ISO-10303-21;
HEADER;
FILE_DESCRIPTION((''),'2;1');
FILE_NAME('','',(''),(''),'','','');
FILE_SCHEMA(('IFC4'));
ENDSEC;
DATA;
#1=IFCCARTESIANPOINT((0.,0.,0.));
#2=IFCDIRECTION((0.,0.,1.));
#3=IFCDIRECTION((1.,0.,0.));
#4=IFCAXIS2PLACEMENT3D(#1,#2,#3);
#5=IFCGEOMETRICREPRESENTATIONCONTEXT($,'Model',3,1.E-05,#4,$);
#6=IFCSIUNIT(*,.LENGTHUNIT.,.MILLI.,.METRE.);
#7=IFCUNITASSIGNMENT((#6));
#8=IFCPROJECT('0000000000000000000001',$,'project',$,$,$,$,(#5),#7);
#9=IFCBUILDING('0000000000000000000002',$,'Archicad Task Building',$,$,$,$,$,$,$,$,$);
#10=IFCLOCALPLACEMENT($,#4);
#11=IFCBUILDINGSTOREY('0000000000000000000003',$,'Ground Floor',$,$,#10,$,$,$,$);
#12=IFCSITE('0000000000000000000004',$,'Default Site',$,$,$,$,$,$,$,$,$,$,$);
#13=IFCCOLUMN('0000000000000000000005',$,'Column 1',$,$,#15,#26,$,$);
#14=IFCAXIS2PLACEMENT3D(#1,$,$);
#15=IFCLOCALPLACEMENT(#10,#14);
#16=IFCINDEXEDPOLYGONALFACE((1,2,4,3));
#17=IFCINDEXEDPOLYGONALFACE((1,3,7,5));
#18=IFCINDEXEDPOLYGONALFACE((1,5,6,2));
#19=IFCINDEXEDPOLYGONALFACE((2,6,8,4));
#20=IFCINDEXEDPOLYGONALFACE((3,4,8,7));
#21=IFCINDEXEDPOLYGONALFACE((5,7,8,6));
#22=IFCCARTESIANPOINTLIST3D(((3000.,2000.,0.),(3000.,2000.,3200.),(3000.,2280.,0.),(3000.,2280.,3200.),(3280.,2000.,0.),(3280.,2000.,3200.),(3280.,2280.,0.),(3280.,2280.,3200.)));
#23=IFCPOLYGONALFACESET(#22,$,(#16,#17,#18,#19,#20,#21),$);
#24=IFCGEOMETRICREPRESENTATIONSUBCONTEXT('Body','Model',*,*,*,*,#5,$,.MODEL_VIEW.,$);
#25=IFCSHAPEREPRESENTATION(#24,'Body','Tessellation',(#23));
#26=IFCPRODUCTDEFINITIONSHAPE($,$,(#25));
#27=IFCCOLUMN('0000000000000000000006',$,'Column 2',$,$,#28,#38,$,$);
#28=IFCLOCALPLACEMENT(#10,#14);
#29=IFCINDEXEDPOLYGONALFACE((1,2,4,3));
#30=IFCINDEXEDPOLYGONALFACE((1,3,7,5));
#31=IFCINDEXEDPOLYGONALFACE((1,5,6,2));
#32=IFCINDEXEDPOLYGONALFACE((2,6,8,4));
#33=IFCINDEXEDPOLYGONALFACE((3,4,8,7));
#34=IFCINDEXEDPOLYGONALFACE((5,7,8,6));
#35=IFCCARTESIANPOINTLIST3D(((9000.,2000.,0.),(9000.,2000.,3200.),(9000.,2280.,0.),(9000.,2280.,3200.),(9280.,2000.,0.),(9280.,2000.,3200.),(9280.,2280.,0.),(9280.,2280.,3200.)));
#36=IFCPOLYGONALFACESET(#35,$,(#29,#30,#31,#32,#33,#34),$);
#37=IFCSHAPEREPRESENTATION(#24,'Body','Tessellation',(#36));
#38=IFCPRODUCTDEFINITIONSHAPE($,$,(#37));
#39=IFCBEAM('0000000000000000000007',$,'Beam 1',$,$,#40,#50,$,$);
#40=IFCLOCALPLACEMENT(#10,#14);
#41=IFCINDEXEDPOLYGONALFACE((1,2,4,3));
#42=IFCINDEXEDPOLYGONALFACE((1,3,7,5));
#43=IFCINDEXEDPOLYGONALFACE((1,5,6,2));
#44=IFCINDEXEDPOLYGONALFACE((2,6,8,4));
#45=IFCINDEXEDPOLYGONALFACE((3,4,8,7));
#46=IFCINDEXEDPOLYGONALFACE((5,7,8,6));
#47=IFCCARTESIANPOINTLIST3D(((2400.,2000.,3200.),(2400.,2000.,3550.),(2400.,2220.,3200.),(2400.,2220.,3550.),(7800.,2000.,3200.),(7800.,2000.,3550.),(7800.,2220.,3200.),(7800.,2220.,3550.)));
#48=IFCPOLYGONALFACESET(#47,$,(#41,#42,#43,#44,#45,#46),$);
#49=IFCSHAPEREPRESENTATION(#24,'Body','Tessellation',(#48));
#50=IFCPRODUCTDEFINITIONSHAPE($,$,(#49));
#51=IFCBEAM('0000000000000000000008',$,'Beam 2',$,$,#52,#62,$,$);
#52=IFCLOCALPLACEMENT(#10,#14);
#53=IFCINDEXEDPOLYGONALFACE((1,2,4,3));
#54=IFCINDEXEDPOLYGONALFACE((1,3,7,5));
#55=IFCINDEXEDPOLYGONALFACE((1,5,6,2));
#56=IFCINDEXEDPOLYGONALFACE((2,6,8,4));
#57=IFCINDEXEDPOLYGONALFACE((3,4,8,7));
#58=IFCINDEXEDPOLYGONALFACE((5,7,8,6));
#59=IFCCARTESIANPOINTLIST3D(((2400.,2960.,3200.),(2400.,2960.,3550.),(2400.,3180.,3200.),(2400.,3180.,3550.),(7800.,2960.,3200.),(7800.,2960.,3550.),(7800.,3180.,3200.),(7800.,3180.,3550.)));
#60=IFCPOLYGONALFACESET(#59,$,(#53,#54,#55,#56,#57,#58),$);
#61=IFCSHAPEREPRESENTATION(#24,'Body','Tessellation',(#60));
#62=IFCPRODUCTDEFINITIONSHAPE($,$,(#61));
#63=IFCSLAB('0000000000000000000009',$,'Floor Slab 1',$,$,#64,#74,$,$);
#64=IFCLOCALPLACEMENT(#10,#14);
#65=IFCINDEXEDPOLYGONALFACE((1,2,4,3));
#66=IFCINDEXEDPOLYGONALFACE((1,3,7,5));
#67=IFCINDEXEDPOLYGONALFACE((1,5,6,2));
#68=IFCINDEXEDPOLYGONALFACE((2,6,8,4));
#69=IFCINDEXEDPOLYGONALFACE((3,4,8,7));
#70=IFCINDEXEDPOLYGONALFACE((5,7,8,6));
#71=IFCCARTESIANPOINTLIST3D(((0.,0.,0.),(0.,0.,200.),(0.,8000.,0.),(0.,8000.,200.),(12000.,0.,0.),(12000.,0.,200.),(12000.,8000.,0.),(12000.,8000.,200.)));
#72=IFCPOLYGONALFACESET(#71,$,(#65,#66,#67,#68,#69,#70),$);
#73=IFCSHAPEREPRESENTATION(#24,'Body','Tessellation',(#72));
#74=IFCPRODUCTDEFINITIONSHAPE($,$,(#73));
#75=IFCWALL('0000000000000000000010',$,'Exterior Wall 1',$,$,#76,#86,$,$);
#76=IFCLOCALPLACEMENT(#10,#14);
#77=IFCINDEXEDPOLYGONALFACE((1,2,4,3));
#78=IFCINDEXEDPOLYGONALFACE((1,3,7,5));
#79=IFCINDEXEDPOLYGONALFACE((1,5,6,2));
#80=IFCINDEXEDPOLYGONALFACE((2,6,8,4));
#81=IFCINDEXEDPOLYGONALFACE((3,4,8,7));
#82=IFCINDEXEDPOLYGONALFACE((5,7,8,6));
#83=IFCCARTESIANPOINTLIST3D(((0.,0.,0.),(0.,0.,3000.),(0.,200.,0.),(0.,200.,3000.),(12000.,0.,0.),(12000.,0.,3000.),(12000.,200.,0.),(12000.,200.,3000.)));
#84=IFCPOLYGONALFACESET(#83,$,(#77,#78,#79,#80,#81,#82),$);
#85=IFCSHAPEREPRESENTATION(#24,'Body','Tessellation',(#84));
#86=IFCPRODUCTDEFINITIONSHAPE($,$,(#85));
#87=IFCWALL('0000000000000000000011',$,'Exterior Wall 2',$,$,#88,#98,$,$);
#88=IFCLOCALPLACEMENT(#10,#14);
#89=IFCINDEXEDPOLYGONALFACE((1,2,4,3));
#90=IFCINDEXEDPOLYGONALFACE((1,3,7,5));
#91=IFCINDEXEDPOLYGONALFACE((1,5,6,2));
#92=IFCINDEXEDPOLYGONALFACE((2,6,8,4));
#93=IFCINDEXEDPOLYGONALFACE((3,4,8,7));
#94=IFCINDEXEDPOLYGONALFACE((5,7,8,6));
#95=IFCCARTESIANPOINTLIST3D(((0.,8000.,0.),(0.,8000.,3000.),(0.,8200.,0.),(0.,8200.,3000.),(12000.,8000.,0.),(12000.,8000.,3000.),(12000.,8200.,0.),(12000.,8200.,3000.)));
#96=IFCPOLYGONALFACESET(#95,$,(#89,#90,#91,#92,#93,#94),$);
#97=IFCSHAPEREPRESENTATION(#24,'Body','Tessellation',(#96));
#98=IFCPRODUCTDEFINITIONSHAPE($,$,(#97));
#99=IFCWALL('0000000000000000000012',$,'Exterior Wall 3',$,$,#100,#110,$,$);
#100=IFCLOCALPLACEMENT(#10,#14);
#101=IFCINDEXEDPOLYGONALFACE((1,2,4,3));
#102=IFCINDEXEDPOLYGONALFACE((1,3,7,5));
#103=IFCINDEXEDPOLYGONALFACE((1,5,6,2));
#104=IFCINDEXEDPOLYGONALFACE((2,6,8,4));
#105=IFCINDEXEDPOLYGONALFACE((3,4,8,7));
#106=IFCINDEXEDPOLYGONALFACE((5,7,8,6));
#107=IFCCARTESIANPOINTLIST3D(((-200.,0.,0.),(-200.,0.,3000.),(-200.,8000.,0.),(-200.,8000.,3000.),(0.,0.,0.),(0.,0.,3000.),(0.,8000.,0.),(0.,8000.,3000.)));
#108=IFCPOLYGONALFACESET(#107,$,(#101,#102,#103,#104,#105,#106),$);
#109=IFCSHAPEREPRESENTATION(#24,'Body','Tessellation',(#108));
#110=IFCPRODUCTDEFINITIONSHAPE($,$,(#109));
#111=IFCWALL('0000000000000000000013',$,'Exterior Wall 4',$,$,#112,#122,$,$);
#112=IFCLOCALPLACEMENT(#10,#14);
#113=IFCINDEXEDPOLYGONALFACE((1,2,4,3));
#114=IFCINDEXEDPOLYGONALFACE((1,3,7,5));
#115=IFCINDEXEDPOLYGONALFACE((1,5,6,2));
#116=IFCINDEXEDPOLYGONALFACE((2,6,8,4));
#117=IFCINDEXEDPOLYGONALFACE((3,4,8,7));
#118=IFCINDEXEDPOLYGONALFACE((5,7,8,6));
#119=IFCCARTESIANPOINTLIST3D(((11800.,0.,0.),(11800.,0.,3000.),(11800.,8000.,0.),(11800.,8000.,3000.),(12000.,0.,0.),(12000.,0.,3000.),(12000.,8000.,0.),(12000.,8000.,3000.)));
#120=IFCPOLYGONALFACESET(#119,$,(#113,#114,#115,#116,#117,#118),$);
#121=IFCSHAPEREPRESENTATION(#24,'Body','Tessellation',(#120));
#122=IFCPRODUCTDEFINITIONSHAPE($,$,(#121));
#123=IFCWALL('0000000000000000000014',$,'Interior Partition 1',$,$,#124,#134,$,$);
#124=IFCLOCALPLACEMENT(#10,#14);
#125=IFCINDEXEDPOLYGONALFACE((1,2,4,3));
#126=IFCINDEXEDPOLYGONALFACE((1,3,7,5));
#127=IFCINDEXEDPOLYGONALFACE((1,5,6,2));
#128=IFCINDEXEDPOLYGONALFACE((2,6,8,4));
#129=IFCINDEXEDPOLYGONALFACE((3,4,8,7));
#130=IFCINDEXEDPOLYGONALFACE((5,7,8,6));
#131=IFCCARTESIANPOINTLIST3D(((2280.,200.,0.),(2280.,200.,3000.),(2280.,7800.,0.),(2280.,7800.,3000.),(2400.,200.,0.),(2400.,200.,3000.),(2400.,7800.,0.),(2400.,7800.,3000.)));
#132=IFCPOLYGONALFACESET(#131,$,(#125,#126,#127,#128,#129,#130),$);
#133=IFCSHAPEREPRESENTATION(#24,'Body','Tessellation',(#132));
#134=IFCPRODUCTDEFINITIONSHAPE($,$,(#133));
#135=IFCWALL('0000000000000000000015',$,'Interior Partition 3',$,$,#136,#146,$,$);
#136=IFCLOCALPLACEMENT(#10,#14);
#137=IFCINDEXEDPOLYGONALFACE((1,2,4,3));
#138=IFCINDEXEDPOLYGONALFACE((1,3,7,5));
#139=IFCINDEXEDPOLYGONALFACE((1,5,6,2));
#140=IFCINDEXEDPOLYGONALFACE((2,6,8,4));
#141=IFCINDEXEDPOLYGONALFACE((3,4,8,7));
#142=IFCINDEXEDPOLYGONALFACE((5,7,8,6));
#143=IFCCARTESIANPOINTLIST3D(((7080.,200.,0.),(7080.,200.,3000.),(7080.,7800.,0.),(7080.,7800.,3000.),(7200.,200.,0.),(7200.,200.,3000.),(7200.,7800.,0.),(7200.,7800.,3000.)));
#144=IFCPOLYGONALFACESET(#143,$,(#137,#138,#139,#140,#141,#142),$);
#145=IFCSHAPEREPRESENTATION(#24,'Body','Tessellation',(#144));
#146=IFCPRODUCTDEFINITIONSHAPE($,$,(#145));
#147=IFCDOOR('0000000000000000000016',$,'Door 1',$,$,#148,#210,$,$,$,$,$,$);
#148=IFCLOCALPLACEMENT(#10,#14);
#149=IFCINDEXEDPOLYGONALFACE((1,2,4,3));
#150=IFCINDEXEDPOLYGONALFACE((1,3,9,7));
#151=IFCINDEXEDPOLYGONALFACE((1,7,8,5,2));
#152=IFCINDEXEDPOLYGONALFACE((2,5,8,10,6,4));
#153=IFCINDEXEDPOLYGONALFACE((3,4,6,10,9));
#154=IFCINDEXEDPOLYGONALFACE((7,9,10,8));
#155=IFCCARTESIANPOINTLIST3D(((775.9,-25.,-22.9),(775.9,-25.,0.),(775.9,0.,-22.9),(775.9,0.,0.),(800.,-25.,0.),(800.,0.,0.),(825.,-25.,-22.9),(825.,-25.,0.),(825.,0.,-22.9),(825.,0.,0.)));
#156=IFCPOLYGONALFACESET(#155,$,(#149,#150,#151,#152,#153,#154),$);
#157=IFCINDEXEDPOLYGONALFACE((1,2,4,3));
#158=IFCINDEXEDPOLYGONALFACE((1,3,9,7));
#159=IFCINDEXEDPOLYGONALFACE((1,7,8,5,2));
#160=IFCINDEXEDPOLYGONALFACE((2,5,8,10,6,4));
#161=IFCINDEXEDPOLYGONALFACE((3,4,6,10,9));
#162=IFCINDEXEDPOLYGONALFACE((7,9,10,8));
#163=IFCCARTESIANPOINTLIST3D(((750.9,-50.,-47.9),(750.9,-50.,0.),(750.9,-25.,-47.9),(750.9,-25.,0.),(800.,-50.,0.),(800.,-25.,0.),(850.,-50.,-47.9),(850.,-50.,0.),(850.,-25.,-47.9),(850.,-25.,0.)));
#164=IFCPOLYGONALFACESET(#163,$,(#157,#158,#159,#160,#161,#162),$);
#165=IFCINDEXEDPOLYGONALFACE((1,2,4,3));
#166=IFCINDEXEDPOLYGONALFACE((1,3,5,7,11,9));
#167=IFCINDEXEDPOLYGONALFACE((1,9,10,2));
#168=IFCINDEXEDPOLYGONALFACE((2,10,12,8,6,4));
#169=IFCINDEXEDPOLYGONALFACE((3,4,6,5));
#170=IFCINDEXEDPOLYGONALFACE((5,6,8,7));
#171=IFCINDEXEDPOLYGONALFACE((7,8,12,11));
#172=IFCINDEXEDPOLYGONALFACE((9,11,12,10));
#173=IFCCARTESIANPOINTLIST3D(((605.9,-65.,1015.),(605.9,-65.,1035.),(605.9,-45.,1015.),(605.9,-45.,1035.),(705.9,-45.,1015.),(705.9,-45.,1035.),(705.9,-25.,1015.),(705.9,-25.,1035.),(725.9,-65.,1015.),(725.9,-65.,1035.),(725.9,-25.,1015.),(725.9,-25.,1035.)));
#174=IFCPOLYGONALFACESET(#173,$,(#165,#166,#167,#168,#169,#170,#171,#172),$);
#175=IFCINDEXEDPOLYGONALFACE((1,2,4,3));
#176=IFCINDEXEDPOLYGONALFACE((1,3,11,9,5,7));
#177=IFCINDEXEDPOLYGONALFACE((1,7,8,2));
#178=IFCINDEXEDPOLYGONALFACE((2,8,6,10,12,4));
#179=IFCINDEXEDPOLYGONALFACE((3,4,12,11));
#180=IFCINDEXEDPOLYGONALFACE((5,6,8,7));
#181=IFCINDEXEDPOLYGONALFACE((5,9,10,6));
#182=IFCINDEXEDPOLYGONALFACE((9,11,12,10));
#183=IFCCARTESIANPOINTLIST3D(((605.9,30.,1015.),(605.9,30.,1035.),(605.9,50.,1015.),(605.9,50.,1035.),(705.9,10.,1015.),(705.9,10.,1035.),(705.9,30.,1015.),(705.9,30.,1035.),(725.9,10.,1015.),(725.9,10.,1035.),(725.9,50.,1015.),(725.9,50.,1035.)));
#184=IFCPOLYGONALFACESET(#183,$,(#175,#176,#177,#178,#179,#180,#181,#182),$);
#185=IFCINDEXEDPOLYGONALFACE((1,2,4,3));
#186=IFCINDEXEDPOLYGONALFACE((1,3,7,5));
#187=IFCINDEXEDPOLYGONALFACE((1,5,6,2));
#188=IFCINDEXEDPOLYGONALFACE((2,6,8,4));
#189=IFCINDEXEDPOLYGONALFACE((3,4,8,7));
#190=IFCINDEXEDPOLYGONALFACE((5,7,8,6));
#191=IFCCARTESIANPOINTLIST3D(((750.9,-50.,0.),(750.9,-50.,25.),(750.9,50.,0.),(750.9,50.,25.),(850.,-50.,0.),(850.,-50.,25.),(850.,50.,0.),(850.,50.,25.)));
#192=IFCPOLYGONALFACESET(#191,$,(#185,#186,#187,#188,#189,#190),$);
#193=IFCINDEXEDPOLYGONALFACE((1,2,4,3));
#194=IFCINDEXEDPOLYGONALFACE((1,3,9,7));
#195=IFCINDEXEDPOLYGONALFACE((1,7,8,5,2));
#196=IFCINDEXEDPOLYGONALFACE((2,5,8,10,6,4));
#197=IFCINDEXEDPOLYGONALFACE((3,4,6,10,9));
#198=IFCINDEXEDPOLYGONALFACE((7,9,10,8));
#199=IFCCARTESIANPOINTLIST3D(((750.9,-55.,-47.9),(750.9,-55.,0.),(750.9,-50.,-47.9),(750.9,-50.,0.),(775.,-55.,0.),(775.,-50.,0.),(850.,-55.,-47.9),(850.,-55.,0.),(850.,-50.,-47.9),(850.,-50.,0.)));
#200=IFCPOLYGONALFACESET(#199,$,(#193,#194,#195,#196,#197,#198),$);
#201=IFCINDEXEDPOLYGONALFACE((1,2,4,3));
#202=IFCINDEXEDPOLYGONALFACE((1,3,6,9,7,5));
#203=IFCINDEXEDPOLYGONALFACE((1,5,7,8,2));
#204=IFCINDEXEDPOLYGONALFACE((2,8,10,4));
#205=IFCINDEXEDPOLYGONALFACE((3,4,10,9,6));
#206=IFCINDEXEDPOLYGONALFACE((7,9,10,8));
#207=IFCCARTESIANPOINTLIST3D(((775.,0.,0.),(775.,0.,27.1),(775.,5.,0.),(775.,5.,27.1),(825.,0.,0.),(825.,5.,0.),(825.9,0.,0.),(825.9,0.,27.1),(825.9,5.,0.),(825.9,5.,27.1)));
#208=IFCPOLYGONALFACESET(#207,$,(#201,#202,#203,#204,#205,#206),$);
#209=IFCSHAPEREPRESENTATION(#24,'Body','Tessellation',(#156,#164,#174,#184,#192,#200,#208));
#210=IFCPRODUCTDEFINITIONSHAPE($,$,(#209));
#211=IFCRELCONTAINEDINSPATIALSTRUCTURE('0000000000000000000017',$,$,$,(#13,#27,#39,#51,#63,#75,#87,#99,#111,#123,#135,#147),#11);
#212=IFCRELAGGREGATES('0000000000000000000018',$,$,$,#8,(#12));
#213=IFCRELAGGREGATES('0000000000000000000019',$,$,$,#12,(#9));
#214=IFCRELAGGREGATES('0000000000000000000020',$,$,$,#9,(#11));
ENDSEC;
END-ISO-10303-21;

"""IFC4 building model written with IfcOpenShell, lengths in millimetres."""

from ifc_helpers import new_model, si_unit, frame, origin_with_axes, place, context, subcontext, project, spatial, line, indexed_curve, outline, extrude, element, save


model = new_model("IFC4")

# Units and contexts
model_context = context("Model", 3, precision=1e-05, world=origin_with_axes())
body_context = subcontext(model_context, "Body", "Model", "MODEL_VIEW")
ifc_project = project(units=[si_unit("LENGTHUNIT", "METRE", prefix="MILLI")], contexts=[model_context])

# Site, building, storey
site = spatial("IfcSite", under=ifc_project, Name="Default Site")
building = spatial("IfcBuilding", under=site, Name="Archicad Task Building")
storey_placement = place(None, origin_with_axes())
storey = spatial("IfcBuildingStorey", under=building, at=storey_placement, Name="Ground Floor")

# Columns
for number, where, z_axis, x_axis, name in (
    (1, (3000.0, 2000.0, 0.0), (0.0, 0.0, 1.0), (1.0, 0.0, 0.0), "Column 1"),
    (2, (9000.0, 2000.0, 0.0), (0.0, 0.0, 1.0), (1.0, 0.0, 0.0), "Column 2"),
):
    element("IfcColumn", number, at=place(storey_placement, frame(where, z_axis=z_axis, x_axis=x_axis)), inside=storey, Name=name, context=body_context, shape_type="SweptSolid", body=[
        extrude(outline(indexed_curve([(0.0, 0.0), (0.0, 280.0), (280.0, 280.0), (280.0, 0.0), (0.0, 0.0)], self_intersect=False)), origin_with_axes(), (0.0, 0.0, 1.0), 3200.0),
    ])

# Beams
for number, where, z_axis, x_axis, name in (
    (3, (2400.0, 2000.0, 3200.0), (0.0, 0.0, 1.0), (1.0, 0.0, 0.0), "Beam 1"),
    (4, (2400.0, 2960.0, 3200.0), (0.0, 0.0, 1.0), (1.0, 0.0, 0.0), "Beam 2"),
):
    element("IfcBeam", number, at=place(storey_placement, frame(where, z_axis=z_axis, x_axis=x_axis)), inside=storey, Name=name, context=body_context, shape_type="SweptSolid", body=[
        extrude(outline(indexed_curve([(0.0, 0.0), (0.0, 220.0), (5400.0, 220.0), (5400.0, 0.0), (0.0, 0.0)], self_intersect=False)), origin_with_axes(), (0.0, 0.0, 1.0), 350.0),
    ])

# Slab
slab_placement = place(storey_placement, origin_with_axes())
element("IfcSlab", 5, at=slab_placement, inside=storey, Name="Floor Slab 1", context=body_context, shape_type="SweptSolid", body=[
    extrude(outline(indexed_curve([(0.0, 0.0), (12000.0, 0.0), (12000.0, 8000.0), (0.0, 8000.0), (0.0, 0.0)])), None, (0.0, 0.0, 1.0), 200.0),
])

# Walls
for number, where, z_axis, x_axis, name in (
    (6, (0.0, 0.0, 0.0), (0.0, 0.0, 1.0), (1.0, 0.0, 0.0), "Exterior Wall 1"),
    (7, (0.0, 8000.0, 0.0), (0.0, 0.0, 1.0), (1.0, 0.0, 0.0), "Exterior Wall 2"),
):
    element("IfcWall", number, at=place(storey_placement, frame(where, z_axis=z_axis, x_axis=x_axis)), inside=storey, Name=name, context=body_context, shape_type="SweptSolid", body=[
        extrude(outline(indexed_curve([(0.0, 0.0), (0.0, 200.0), (12000.0, 200.0), (12000.0, 0.0), (0.0, 0.0)], self_intersect=False)), origin_with_axes(), (0.0, 0.0, 1.0), 3000.0),
    ])
for number, where, z_axis, x_axis, name in (
    (8, (0.0, 0.0, 0.0), (0.0, 0.0, 1.0), (0.0, 1.0, 0.0), "Exterior Wall 3"),
    (9, (12000.0, 0.0, 0.0), (0.0, 0.0, 1.0), (0.0, 1.0, 0.0), "Exterior Wall 4"),
):
    element("IfcWall", number, at=place(storey_placement, frame(where, z_axis=z_axis, x_axis=x_axis)), inside=storey, Name=name, context=body_context, shape_type="SweptSolid", body=[
        extrude(outline(indexed_curve([(0.0, 0.0), (0.0, 200.0), (8000.0, 200.0), (8000.0, 0.0), (0.0, 0.0)], self_intersect=False)), origin_with_axes(), (0.0, 0.0, 1.0), 3000.0),
    ])
for number, where, z_axis, x_axis, name in (
    (10, (2400.0, 200.0, 0.0), (0.0, 0.0, 1.0), (0.0, 1.0, 0.0), "Interior Partition 1"),
    (11, (7200.0, 200.0, 0.0), (0.0, 0.0, 1.0), (0.0, 1.0, 0.0), "Interior Partition 3"),
):
    element("IfcWall", number, at=place(storey_placement, frame(where, z_axis=z_axis, x_axis=x_axis)), inside=storey, Name=name, context=body_context, shape_type="SweptSolid", body=[
        extrude(outline(indexed_curve([(0.0, 0.0), (0.0, 120.0), (7600.0, 120.0), (7600.0, 0.0), (0.0, 0.0)], self_intersect=False)), origin_with_axes(), (0.0, 0.0, 1.0), 3000.0),
    ])

# Door
door_1_placement = place(storey_placement, frame((800.0, -50.0, 0.0), z_axis=(0.0, 0.0, 1.0), x_axis=(1.0, 0.0, 0.0)))
element("IfcDoor", 12, at=door_1_placement, inside=storey, Name="Door 1", context=body_context, shape_type="SweptSolid", body=[
    extrude(outline(indexed_curve([(0.0, 0.0), (0.0, 2.1), (0.9, 2.1), (0.9, 0.0), (-24.1, 0.0), (-24.1, -22.9), (25.0, -22.9), (25.0, 0.0)], segments=[line(1, 2, 3, 4, 5, 6, 7, 8, 1)])), frame((0.0, 25.0, 0.0), z_axis=(0.0, -1.0, 0.0), x_axis=(1.0, 0.0, 0.0)), (0.0, 0.0, -1.0), 25.0),
    extrude(outline(indexed_curve([(0.0, 0.0), (0.0, 2.1), (0.9, 2.1), (0.9, 0.0), (-49.1, 0.0), (-49.1, -47.9), (50.0, -47.9), (50.0, 0.0)], segments=[line(1, 2, 3, 4, 5, 6, 7, 8, 1)])), frame((0.0, 0.0, 0.0), z_axis=(0.0, -1.0, 0.0), x_axis=(1.0, 0.0, 0.0)), (0.0, 0.0, -1.0), 25.0),
    extrude(outline(indexed_curve([(0.0, 0.0), (-49.1, 0.0), (-49.1, 35.0), (0.0, 35.0)], segments=[line(1, 2, 3, 4, 1)])), frame((25.0, 25.0, 25.0), z_axis=(0.0, 0.0, 1.0), x_axis=(1.0, 0.0, 0.0)), (0.0, 0.0, 1.0), -47.9),
    extrude(outline(indexed_curve([(0.0, 0.0), (0.0, -40.0), (-120.0, -40.0), (-120.0, -20.0), (-20.0, -20.0), (-20.0, 0.0)], segments=[line(1, 2, 3, 4, 5, 6, 1)])), frame((-74.1, 25.0, 1015.0), z_axis=(0.0, 0.0, 1.0), x_axis=(1.0, 0.0, 0.0)), (0.0, 0.0, 1.0), 20.0),
    extrude(outline(indexed_curve([(0.0, 0.0), (0.0, 40.0), (-120.0, 40.0), (-120.0, 20.0), (-20.0, 20.0), (-20.0, 0.0)], segments=[line(1, 2, 3, 4, 5, 6, 1)])), frame((-74.1, 60.0, 1015.0), z_axis=(0.0, 0.0, 1.0), x_axis=(1.0, 0.0, 0.0)), (0.0, 0.0, 1.0), 20.0),
    extrude(outline(indexed_curve([(0.0, 0.0), (-99.1, 0.0), (-99.1, 100.0), (0.0, 100.0)], segments=[line(1, 2, 3, 4, 1)])), frame((50.0, 0.0, 0.0), z_axis=(0.0, 0.0, 1.0), x_axis=(1.0, 0.0, 0.0)), (0.0, 0.0, 1.0), 25.0),
    extrude(outline(indexed_curve([(0.0, 0.0), (0.0, 27.1), (50.9, 27.1), (50.9, 0.0), (-24.1, 0.0), (-24.1, -47.9), (75.0, -47.9), (75.0, 0.0)], segments=[line(1, 2, 3, 4, 5, 6, 7, 8, 1)])), frame((-25.0, -5.0, 0.0), z_axis=(0.0, -1.0, 0.0), x_axis=(1.0, 0.0, 0.0)), (0.0, 0.0, -1.0), 5.0),
    extrude(outline(indexed_curve([(0.0, 0.0), (0.0, 27.1), (50.9, 27.1), (50.9, 0.0), (0.9, 0.0), (0.9, -22.9), (50.0, -22.9), (50.0, 0.0)], segments=[line(1, 2, 3, 4, 5, 6, 7, 8, 1)])), frame((-25.0, 50.0, 0.0), z_axis=(0.0, -1.0, 0.0), x_axis=(1.0, 0.0, 0.0)), (0.0, 0.0, -1.0), 5.0),
])

save(model, "model.ifc")
